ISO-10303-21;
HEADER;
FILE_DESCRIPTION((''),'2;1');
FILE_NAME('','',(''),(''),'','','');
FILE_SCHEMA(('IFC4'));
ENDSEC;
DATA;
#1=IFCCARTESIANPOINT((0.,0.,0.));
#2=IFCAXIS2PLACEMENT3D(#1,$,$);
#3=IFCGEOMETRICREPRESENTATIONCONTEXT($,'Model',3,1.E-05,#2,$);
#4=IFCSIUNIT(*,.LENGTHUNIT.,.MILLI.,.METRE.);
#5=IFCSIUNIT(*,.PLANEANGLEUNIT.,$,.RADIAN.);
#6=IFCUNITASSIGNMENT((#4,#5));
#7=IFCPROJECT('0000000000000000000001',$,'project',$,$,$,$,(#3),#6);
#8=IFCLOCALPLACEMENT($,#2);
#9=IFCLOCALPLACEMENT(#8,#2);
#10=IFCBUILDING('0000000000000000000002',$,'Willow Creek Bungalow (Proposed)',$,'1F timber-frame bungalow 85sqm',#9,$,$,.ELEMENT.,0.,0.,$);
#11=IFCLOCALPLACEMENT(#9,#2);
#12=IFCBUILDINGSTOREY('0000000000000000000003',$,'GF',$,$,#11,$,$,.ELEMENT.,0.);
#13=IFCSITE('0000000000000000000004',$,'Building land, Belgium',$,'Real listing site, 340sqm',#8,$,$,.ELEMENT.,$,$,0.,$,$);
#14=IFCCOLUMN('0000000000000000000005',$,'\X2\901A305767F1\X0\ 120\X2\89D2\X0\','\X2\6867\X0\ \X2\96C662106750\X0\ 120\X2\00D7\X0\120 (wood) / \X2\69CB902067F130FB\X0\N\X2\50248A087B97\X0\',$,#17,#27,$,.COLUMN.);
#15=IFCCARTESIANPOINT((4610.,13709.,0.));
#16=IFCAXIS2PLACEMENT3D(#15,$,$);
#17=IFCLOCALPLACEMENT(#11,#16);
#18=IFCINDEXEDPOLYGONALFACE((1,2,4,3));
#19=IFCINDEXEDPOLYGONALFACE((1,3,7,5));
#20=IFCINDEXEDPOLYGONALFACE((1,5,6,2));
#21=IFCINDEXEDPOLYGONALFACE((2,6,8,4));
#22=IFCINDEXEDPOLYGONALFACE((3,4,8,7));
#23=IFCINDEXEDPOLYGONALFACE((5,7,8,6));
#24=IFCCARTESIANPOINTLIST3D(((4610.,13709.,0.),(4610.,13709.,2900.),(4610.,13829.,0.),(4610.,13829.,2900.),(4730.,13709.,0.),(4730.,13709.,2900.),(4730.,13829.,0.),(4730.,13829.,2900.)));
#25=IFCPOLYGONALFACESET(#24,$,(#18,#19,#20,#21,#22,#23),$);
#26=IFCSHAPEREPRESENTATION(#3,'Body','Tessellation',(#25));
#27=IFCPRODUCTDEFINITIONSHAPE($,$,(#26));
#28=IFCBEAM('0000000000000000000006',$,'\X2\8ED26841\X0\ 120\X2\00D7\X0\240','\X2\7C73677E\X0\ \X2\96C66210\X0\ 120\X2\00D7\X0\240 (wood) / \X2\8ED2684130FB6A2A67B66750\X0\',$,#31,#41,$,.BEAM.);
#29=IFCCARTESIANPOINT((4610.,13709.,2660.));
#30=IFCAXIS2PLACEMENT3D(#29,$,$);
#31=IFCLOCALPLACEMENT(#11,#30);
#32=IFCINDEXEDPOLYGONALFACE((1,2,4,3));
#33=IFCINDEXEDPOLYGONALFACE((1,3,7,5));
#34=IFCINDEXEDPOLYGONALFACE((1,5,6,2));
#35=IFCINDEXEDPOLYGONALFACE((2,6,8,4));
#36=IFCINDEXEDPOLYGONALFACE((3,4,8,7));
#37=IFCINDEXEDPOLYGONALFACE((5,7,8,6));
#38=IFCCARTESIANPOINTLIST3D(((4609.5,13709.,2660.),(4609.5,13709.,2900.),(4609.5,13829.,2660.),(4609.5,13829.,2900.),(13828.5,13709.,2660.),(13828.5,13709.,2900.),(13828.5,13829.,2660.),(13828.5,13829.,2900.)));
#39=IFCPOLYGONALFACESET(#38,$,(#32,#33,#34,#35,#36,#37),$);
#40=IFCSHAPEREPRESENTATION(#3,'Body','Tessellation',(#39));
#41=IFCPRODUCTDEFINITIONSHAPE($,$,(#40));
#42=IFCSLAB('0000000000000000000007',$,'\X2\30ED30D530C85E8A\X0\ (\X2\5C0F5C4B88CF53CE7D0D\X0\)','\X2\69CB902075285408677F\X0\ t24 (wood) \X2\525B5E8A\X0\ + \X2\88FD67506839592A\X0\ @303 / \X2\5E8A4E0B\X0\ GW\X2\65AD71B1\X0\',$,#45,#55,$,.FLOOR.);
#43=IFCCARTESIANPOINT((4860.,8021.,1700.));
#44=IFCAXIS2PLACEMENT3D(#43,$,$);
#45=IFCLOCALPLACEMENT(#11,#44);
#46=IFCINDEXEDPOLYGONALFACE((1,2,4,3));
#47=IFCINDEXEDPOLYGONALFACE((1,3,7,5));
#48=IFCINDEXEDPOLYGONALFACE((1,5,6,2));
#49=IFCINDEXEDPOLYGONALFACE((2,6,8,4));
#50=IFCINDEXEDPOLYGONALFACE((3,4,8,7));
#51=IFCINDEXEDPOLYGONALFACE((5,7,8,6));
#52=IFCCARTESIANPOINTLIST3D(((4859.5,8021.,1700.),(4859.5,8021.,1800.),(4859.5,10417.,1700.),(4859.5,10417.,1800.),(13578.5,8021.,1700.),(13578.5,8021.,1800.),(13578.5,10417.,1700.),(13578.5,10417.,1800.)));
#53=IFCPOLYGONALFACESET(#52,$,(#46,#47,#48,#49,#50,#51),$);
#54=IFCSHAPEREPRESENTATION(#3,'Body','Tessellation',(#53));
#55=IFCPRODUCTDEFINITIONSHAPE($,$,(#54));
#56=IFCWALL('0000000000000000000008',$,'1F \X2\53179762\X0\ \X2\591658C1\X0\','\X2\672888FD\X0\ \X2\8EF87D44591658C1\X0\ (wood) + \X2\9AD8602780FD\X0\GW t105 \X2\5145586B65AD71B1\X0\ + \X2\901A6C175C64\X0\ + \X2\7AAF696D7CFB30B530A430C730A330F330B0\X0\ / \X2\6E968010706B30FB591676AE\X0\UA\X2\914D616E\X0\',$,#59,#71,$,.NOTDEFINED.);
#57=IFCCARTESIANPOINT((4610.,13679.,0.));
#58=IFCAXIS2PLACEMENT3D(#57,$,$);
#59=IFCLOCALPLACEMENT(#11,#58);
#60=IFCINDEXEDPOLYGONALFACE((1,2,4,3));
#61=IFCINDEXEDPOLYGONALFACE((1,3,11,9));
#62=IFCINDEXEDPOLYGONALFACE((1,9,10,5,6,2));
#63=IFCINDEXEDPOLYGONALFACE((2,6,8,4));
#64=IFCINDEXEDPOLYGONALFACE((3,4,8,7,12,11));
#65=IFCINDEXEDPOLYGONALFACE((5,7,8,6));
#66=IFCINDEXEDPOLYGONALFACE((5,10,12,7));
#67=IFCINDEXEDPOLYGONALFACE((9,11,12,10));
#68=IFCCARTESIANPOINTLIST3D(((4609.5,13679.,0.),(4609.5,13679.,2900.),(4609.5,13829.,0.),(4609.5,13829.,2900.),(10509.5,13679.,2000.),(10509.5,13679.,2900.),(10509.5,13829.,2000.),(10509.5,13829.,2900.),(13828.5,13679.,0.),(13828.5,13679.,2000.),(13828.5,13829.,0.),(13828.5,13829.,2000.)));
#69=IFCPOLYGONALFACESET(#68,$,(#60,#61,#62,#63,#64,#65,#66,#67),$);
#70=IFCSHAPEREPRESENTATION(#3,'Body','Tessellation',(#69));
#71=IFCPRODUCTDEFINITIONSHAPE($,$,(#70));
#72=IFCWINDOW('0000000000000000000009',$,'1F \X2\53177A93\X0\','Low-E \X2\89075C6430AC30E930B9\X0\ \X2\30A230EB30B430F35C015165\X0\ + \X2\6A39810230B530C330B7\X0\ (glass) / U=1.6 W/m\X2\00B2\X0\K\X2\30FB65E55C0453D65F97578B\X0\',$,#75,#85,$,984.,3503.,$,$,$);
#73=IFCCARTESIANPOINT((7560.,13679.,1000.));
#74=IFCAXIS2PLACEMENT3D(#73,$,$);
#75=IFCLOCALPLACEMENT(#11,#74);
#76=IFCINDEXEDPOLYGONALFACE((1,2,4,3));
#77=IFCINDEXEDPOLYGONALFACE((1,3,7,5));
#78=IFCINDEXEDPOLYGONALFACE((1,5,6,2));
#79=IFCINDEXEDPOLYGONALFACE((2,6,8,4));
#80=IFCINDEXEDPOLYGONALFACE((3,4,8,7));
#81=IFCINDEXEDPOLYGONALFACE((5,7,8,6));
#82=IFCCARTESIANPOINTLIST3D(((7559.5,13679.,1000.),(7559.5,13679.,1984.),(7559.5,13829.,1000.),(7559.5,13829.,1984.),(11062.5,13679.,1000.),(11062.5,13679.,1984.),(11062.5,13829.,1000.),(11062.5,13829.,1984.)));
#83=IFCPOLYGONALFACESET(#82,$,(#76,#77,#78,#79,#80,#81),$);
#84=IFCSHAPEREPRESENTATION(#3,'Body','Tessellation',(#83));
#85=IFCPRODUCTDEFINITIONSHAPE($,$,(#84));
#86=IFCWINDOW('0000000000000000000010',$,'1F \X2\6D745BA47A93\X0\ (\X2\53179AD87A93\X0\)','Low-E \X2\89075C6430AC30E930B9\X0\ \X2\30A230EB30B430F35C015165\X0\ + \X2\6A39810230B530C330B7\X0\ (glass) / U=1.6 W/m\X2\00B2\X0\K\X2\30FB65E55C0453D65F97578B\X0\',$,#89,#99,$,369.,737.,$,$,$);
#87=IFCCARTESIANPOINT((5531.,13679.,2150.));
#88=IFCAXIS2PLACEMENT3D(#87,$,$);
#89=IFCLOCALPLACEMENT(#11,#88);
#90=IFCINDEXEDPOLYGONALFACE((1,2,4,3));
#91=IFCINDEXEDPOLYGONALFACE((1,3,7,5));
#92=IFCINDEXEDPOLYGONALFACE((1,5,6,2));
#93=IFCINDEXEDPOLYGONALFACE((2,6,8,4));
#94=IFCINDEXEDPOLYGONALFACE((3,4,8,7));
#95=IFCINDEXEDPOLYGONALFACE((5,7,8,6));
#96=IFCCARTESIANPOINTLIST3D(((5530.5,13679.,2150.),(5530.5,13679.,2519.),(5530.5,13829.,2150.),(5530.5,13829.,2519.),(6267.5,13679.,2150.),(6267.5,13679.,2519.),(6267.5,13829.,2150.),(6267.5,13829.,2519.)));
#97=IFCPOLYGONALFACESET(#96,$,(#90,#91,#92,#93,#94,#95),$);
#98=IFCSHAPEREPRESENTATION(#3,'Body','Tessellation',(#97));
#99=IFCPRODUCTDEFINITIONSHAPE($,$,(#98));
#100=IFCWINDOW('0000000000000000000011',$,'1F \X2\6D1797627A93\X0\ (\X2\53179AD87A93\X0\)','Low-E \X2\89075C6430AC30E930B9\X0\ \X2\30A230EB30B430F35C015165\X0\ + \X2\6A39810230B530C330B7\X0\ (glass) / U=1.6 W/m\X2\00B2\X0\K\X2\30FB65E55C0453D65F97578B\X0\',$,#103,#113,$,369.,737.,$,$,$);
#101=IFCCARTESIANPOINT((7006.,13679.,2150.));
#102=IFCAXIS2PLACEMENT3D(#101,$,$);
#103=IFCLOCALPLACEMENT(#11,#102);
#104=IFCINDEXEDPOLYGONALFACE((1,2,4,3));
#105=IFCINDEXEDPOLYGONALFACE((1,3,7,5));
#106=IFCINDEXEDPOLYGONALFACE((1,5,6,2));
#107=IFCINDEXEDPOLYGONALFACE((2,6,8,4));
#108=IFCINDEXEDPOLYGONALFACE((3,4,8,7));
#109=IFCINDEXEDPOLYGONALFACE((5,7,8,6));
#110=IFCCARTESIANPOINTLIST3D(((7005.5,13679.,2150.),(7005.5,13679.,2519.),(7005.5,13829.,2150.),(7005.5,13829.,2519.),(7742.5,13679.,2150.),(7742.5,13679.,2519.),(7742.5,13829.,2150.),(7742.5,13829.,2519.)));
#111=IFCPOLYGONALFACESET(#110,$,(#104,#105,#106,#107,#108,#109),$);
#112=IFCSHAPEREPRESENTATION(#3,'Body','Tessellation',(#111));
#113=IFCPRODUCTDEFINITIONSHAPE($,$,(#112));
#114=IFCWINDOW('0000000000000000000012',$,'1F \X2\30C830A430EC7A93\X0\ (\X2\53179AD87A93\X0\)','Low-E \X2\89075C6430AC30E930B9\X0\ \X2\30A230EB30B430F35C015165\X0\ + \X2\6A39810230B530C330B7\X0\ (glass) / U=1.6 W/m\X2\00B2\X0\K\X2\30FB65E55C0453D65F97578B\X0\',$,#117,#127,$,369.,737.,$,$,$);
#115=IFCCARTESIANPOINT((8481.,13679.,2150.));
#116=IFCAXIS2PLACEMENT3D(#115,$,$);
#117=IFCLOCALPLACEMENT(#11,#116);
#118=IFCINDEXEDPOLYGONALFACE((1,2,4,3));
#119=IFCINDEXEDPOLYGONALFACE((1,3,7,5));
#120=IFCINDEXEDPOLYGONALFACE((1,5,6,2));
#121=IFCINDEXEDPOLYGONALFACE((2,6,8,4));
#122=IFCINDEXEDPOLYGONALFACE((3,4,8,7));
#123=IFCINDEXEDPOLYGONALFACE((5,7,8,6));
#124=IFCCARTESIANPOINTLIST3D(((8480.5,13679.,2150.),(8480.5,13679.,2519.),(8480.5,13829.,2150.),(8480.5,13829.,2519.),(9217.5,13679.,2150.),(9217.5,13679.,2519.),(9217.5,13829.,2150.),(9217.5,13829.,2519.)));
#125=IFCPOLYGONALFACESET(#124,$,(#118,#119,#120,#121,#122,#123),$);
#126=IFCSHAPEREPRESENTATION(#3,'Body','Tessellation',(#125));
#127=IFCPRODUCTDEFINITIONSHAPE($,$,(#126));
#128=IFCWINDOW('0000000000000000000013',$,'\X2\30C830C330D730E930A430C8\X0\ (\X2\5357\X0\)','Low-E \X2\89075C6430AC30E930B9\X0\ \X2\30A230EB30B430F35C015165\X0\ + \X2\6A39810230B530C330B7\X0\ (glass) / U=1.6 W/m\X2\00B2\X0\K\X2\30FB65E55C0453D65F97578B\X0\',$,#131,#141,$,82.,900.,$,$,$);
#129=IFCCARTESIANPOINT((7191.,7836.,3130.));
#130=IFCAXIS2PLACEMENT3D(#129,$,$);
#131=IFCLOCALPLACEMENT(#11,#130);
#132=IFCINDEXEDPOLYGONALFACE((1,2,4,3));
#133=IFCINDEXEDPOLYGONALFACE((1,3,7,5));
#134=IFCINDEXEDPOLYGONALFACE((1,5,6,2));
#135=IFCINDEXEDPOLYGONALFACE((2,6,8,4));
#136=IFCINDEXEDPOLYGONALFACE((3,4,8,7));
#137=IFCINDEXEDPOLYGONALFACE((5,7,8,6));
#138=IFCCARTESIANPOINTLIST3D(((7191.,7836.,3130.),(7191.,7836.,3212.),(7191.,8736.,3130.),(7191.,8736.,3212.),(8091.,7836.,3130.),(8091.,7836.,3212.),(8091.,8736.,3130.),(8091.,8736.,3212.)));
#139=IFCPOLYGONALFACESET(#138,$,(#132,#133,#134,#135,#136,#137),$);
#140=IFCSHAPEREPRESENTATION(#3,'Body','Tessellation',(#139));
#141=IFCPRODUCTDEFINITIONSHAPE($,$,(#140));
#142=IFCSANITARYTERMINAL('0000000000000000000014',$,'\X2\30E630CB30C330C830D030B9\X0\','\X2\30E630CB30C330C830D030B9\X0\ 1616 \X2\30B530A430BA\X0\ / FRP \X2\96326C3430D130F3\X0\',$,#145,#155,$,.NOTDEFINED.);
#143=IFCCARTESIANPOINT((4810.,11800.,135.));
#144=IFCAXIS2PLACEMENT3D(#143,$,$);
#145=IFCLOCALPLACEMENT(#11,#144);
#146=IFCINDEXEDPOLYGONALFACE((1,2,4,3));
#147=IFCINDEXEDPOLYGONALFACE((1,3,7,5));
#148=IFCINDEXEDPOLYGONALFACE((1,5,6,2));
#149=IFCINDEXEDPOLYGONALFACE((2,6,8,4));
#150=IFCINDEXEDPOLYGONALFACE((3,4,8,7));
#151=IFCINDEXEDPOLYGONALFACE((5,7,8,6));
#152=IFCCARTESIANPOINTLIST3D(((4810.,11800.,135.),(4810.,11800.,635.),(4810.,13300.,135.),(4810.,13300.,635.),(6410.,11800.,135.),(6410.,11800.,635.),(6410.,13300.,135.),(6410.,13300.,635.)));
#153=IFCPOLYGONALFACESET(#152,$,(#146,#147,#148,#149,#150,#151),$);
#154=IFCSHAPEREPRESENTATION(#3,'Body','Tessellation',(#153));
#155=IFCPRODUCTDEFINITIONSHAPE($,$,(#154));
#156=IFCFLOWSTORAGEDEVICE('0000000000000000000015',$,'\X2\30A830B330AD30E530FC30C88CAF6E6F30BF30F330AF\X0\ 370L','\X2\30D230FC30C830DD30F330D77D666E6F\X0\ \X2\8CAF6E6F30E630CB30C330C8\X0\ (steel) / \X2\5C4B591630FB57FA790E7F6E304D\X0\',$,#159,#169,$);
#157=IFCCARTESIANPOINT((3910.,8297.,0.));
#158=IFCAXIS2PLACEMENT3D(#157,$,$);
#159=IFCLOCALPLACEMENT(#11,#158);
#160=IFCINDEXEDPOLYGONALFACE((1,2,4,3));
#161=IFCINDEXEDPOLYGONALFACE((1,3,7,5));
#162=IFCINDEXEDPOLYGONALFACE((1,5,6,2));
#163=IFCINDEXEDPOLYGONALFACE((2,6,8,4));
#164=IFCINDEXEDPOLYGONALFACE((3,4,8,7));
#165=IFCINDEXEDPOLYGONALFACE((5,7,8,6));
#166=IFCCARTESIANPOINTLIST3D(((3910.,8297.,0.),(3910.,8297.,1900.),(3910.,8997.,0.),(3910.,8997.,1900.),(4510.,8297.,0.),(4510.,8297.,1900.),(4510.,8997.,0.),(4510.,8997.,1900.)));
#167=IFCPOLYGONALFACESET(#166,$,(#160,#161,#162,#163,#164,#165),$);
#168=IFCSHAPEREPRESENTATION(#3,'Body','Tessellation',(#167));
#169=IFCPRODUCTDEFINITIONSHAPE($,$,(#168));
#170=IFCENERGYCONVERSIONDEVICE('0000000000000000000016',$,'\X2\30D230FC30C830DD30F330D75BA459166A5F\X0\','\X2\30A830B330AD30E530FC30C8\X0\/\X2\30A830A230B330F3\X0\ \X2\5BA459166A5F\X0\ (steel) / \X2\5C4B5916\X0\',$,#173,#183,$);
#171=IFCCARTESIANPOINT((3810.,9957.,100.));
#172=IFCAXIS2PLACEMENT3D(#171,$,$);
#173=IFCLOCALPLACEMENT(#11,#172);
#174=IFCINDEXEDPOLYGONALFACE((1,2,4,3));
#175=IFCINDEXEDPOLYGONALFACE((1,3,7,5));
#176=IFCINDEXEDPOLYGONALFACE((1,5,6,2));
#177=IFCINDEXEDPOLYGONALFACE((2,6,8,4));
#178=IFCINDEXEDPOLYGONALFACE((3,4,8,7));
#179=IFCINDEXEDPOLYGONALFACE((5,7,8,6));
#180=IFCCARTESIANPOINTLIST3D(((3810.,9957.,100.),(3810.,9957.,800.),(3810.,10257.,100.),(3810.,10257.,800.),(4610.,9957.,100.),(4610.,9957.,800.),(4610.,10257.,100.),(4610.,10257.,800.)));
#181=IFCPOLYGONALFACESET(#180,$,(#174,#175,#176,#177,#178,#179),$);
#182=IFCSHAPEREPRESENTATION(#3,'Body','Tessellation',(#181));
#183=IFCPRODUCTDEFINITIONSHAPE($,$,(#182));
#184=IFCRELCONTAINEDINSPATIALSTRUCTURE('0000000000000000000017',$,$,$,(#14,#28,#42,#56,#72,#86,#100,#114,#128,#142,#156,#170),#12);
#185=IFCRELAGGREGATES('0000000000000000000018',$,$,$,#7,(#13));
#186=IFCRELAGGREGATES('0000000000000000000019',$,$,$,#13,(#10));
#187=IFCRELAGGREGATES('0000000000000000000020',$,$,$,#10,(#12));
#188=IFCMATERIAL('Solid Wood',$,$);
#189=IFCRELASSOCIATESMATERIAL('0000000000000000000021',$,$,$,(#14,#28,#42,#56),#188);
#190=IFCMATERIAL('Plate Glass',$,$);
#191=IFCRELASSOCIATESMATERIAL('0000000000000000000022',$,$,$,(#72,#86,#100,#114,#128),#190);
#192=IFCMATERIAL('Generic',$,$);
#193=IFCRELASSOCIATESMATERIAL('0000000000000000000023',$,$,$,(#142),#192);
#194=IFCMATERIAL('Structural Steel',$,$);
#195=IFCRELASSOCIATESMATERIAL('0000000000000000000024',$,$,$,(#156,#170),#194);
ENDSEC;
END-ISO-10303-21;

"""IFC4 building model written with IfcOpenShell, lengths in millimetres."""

from ifc_helpers import new_model, si_unit, frame, frame_2d, origin, place, context, project, spatial, rectangle, extrude, material, element, fill, save


model = new_model("IFC4")

# Units and contexts
model_context = context("Model", 3, precision=1e-05, world=origin())
ifc_project = project(units=[si_unit("LENGTHUNIT", "METRE", prefix="MILLI"), si_unit("PLANEANGLEUNIT", "RADIAN")], contexts=[model_context])

# Site, building, storey
site_placement = place(None, origin())
site = spatial("IfcSite", under=ifc_project, at=site_placement, Name="Building land, Belgium", ObjectType="Real listing site, 340sqm", CompositionType="ELEMENT", RefElevation=0.0)
building_placement = place(site_placement, origin())
building = spatial("IfcBuilding", under=site, at=building_placement, Name="Willow Creek Bungalow (Proposed)", ObjectType="1F timber-frame bungalow 85sqm", CompositionType="ELEMENT", ElevationOfRefHeight=0.0, ElevationOfTerrain=0.0)
storey_placement = place(building_placement, origin())
storey = spatial("IfcBuildingStorey", under=building, at=storey_placement, Name="GF", CompositionType="ELEMENT", Elevation=0.0)

# Column
ifc_material_1 = material(Name="Solid Wood")
column_1_placement = place(storey_placement, frame((4610.0, 13709.0, 0.0)))
element("IfcColumn", 1, at=column_1_placement, inside=storey, material=ifc_material_1, Name="通し柱 120角", Description="桧 集成材 120×120 (wood) / 構造柱・N値計算", PredefinedType="COLUMN", context=model_context, shape_type="SweptSolid", body=[
    extrude(rectangle(XDim=120.0, YDim=120.0, at=frame_2d((60.0, 60.0))), frame((4610.0, 13709.0, 0.0)), (0.0, 0.0, 1.0), 2900.0),
])

# Beam
beam_1_placement = place(storey_placement, frame((4610.0, 13709.0, 2660.0)))
element("IfcBeam", 2, at=beam_1_placement, inside=storey, material=ifc_material_1, Name="軒桁 120×240", Description="米松 集成 120×240 (wood) / 軒桁・横架材", PredefinedType="BEAM", context=model_context, shape_type="SweptSolid", body=[
    extrude(rectangle(XDim=9219.0, YDim=120.0, at=frame_2d((4609.0, 60.0))), frame((4610.0, 13709.0, 2660.0)), (0.0, 0.0, 1.0), 240.0),
])

# Slab
slab_placement = place(storey_placement, frame((4860.0, 8021.0, 1700.0)))
element("IfcSlab", 3, at=slab_placement, inside=storey, material=ifc_material_1, Name="ロフト床 (小屋裏収納)", Description="構造用合板 t24 (wood) 剛床 + 製材根太 @303 / 床下 GW断熱", PredefinedType="FLOOR", context=model_context, shape_type="SweptSolid", body=[
    extrude(rectangle(XDim=8719.0, YDim=2396.0, at=frame_2d((4359.0, 1198.0))), frame((4860.0, 8021.0, 1700.0)), (0.0, 0.0, 1.0), 100.0),
])

# Wall, openings, windows
wall_1_placement = place(storey_placement, frame((4610.0, 13679.0, 0.0)))
wall_1 = element("IfcWall", 4, at=wall_1_placement, inside=storey, material=ifc_material_1, Name="1F 北面 外壁", Description="木製 軸組外壁 (wood) + 高性能GW t105 充填断熱 + 通気層 + 窯業系サイディング / 準耐火・外皮UA配慮", PredefinedType="NOTDEFINED", context=model_context, shape_type="SweptSolid", body=[
    extrude(rectangle(XDim=9219.0, YDim=150.0, at=frame_2d((4609.0, 75.0))), frame((4610.0, 13679.0, 0.0)), (0.0, 0.0, 1.0), 2900.0),
])
opening_1_placement = place(storey_placement, frame((7560.0, 13679.0, 1000.0)))
opening_1 = element("IfcOpeningElement", 5, at=opening_1_placement, cuts=wall_1, PredefinedType="NOTDEFINED", context=model_context, shape_type="SweptSolid", body=[
    extrude(rectangle(XDim=3503.0, YDim=150.0, at=frame_2d((1751.0, 75.0))), frame((7560.0, 13679.0, 1000.0)), (0.0, 0.0, 1.0), 984.0),
])
opening_2_placement = place(storey_placement, frame((5531.0, 13679.0, 2150.0)))
opening_2 = element("IfcOpeningElement", 6, at=opening_2_placement, cuts=wall_1, PredefinedType="NOTDEFINED", context=model_context, shape_type="SweptSolid", body=[
    extrude(rectangle(XDim=737.0, YDim=150.0, at=frame_2d((368.0, 75.0))), frame((5531.0, 13679.0, 2150.0)), (0.0, 0.0, 1.0), 369.0),
])
opening_3_placement = place(storey_placement, frame((7006.0, 13679.0, 2150.0)))
opening_3 = element("IfcOpeningElement", 7, at=opening_3_placement, cuts=wall_1, PredefinedType="NOTDEFINED", context=model_context, shape_type="SweptSolid", body=[
    extrude(rectangle(XDim=737.0, YDim=150.0, at=frame_2d((368.0, 75.0))), frame((7006.0, 13679.0, 2150.0)), (0.0, 0.0, 1.0), 369.0),
])
opening_4_placement = place(storey_placement, frame((8481.0, 13679.0, 2150.0)))
opening_4 = element("IfcOpeningElement", 8, at=opening_4_placement, cuts=wall_1, PredefinedType="NOTDEFINED", context=model_context, shape_type="SweptSolid", body=[
    extrude(rectangle(XDim=737.0, YDim=150.0, at=frame_2d((368.0, 75.0))), frame((8481.0, 13679.0, 2150.0)), (0.0, 0.0, 1.0), 369.0),
])
ifc_material_2 = material(Name="Plate Glass")
window_1_placement = place(storey_placement, frame((7560.0, 13679.0, 1000.0)))
window_1 = element("IfcWindow", 9, at=window_1_placement, inside=storey, material=ifc_material_2, Name="1F 北窓", Description="Low-E 複層ガラス アルゴン封入 + 樹脂サッシ (glass) / U=1.6 W/m²K・日射取得型", OverallHeight=984.0, OverallWidth=3503.0, context=model_context, shape_type="SweptSolid", body=[
    extrude(rectangle(XDim=3503.0, YDim=150.0, at=frame_2d((1751.0, 75.0))), frame((7560.0, 13679.0, 1000.0)), (0.0, 0.0, 1.0), 984.0),
])
fill(opening_1, window_1)
window_2_placement = place(storey_placement, frame((5531.0, 13679.0, 2150.0)))
window_2 = element("IfcWindow", 10, at=window_2_placement, inside=storey, material=ifc_material_2, Name="1F 浴室窓 (北高窓)", Description="Low-E 複層ガラス アルゴン封入 + 樹脂サッシ (glass) / U=1.6 W/m²K・日射取得型", OverallHeight=369.0, OverallWidth=737.0, context=model_context, shape_type="SweptSolid", body=[
    extrude(rectangle(XDim=737.0, YDim=150.0, at=frame_2d((368.0, 75.0))), frame((5531.0, 13679.0, 2150.0)), (0.0, 0.0, 1.0), 369.0),
])
fill(opening_2, window_2)
window_3_placement = place(storey_placement, frame((7006.0, 13679.0, 2150.0)))
window_3 = element("IfcWindow", 11, at=window_3_placement, inside=storey, material=ifc_material_2, Name="1F 洗面窓 (北高窓)", Description="Low-E 複層ガラス アルゴン封入 + 樹脂サッシ (glass) / U=1.6 W/m²K・日射取得型", OverallHeight=369.0, OverallWidth=737.0, context=model_context, shape_type="SweptSolid", body=[
    extrude(rectangle(XDim=737.0, YDim=150.0, at=frame_2d((368.0, 75.0))), frame((7006.0, 13679.0, 2150.0)), (0.0, 0.0, 1.0), 369.0),
])
fill(opening_3, window_3)
window_4_placement = place(storey_placement, frame((8481.0, 13679.0, 2150.0)))
window_4 = element("IfcWindow", 12, at=window_4_placement, inside=storey, material=ifc_material_2, Name="1F トイレ窓 (北高窓)", Description="Low-E 複層ガラス アルゴン封入 + 樹脂サッシ (glass) / U=1.6 W/m²K・日射取得型", OverallHeight=369.0, OverallWidth=737.0, context=model_context, shape_type="SweptSolid", body=[
    extrude(rectangle(XDim=737.0, YDim=150.0, at=frame_2d((368.0, 75.0))), frame((8481.0, 13679.0, 2150.0)), (0.0, 0.0, 1.0), 369.0),
])
fill(opening_4, window_4)

# Window
window_5_placement = place(storey_placement, frame((7191.0, 7836.0, 3130.0)))
element("IfcWindow", 13, at=window_5_placement, inside=storey, material=ifc_material_2, Name="トップライト (南)", Description="Low-E 複層ガラス アルゴン封入 + 樹脂サッシ (glass) / U=1.6 W/m²K・日射取得型", OverallHeight=82.0, OverallWidth=900.0, context=model_context, shape_type="SweptSolid", body=[
    extrude(rectangle(XDim=900.0, YDim=900.0, at=frame_2d((450.0, 450.0))), frame((7191.0, 7836.0, 3130.0)), (0.0, 0.0, 1.0), 82.0),
])

# Sanitary terminal
ifc_material_3 = material(Name="Generic")
sanitary_terminal_placement = place(storey_placement, frame((4810.0, 11800.0, 135.0)))
element("IfcSanitaryTerminal", 14, at=sanitary_terminal_placement, inside=storey, material=ifc_material_3, Name="ユニットバス", Description="ユニットバス 1616 サイズ / FRP 防水パン", PredefinedType="NOTDEFINED", context=model_context, shape_type="SweptSolid", body=[
    extrude(rectangle(XDim=1600.0, YDim=1500.0, at=frame_2d((800.0, 750.0))), frame((4810.0, 11800.0, 135.0)), (0.0, 0.0, 1.0), 500.0),
])

# Flow storage device
ifc_material_4 = material(Name="Structural Steel")
flow_storage_device_placement = place(storey_placement, frame((3910.0, 8297.0, 0.0)))
element("IfcFlowStorageDevice", 15, at=flow_storage_device_placement, inside=storey, material=ifc_material_4, Name="エコキュート貯湯タンク 370L", Description="ヒートポンプ給湯 貯湯ユニット (steel) / 屋外・基礎置き", context=model_context, shape_type="SweptSolid", body=[
    extrude(rectangle(XDim=600.0, YDim=700.0, at=frame_2d((300.0, 350.0))), frame((3910.0, 8297.0, 0.0)), (0.0, 0.0, 1.0), 1900.0),
])

# Energy conversion device
energy_conversion_device_placement = place(storey_placement, frame((3810.0, 9957.0, 100.0)))
element("IfcEnergyConversionDevice", 16, at=energy_conversion_device_placement, inside=storey, material=ifc_material_4, Name="ヒートポンプ室外機", Description="エコキュート/エアコン 室外機 (steel) / 屋外", context=model_context, shape_type="SweptSolid", body=[
    extrude(rectangle(XDim=800.0, YDim=300.0, at=frame_2d((400.0, 150.0))), frame((3810.0, 9957.0, 100.0)), (0.0, 0.0, 1.0), 700.0),
])

save(model, "model.ifc")
